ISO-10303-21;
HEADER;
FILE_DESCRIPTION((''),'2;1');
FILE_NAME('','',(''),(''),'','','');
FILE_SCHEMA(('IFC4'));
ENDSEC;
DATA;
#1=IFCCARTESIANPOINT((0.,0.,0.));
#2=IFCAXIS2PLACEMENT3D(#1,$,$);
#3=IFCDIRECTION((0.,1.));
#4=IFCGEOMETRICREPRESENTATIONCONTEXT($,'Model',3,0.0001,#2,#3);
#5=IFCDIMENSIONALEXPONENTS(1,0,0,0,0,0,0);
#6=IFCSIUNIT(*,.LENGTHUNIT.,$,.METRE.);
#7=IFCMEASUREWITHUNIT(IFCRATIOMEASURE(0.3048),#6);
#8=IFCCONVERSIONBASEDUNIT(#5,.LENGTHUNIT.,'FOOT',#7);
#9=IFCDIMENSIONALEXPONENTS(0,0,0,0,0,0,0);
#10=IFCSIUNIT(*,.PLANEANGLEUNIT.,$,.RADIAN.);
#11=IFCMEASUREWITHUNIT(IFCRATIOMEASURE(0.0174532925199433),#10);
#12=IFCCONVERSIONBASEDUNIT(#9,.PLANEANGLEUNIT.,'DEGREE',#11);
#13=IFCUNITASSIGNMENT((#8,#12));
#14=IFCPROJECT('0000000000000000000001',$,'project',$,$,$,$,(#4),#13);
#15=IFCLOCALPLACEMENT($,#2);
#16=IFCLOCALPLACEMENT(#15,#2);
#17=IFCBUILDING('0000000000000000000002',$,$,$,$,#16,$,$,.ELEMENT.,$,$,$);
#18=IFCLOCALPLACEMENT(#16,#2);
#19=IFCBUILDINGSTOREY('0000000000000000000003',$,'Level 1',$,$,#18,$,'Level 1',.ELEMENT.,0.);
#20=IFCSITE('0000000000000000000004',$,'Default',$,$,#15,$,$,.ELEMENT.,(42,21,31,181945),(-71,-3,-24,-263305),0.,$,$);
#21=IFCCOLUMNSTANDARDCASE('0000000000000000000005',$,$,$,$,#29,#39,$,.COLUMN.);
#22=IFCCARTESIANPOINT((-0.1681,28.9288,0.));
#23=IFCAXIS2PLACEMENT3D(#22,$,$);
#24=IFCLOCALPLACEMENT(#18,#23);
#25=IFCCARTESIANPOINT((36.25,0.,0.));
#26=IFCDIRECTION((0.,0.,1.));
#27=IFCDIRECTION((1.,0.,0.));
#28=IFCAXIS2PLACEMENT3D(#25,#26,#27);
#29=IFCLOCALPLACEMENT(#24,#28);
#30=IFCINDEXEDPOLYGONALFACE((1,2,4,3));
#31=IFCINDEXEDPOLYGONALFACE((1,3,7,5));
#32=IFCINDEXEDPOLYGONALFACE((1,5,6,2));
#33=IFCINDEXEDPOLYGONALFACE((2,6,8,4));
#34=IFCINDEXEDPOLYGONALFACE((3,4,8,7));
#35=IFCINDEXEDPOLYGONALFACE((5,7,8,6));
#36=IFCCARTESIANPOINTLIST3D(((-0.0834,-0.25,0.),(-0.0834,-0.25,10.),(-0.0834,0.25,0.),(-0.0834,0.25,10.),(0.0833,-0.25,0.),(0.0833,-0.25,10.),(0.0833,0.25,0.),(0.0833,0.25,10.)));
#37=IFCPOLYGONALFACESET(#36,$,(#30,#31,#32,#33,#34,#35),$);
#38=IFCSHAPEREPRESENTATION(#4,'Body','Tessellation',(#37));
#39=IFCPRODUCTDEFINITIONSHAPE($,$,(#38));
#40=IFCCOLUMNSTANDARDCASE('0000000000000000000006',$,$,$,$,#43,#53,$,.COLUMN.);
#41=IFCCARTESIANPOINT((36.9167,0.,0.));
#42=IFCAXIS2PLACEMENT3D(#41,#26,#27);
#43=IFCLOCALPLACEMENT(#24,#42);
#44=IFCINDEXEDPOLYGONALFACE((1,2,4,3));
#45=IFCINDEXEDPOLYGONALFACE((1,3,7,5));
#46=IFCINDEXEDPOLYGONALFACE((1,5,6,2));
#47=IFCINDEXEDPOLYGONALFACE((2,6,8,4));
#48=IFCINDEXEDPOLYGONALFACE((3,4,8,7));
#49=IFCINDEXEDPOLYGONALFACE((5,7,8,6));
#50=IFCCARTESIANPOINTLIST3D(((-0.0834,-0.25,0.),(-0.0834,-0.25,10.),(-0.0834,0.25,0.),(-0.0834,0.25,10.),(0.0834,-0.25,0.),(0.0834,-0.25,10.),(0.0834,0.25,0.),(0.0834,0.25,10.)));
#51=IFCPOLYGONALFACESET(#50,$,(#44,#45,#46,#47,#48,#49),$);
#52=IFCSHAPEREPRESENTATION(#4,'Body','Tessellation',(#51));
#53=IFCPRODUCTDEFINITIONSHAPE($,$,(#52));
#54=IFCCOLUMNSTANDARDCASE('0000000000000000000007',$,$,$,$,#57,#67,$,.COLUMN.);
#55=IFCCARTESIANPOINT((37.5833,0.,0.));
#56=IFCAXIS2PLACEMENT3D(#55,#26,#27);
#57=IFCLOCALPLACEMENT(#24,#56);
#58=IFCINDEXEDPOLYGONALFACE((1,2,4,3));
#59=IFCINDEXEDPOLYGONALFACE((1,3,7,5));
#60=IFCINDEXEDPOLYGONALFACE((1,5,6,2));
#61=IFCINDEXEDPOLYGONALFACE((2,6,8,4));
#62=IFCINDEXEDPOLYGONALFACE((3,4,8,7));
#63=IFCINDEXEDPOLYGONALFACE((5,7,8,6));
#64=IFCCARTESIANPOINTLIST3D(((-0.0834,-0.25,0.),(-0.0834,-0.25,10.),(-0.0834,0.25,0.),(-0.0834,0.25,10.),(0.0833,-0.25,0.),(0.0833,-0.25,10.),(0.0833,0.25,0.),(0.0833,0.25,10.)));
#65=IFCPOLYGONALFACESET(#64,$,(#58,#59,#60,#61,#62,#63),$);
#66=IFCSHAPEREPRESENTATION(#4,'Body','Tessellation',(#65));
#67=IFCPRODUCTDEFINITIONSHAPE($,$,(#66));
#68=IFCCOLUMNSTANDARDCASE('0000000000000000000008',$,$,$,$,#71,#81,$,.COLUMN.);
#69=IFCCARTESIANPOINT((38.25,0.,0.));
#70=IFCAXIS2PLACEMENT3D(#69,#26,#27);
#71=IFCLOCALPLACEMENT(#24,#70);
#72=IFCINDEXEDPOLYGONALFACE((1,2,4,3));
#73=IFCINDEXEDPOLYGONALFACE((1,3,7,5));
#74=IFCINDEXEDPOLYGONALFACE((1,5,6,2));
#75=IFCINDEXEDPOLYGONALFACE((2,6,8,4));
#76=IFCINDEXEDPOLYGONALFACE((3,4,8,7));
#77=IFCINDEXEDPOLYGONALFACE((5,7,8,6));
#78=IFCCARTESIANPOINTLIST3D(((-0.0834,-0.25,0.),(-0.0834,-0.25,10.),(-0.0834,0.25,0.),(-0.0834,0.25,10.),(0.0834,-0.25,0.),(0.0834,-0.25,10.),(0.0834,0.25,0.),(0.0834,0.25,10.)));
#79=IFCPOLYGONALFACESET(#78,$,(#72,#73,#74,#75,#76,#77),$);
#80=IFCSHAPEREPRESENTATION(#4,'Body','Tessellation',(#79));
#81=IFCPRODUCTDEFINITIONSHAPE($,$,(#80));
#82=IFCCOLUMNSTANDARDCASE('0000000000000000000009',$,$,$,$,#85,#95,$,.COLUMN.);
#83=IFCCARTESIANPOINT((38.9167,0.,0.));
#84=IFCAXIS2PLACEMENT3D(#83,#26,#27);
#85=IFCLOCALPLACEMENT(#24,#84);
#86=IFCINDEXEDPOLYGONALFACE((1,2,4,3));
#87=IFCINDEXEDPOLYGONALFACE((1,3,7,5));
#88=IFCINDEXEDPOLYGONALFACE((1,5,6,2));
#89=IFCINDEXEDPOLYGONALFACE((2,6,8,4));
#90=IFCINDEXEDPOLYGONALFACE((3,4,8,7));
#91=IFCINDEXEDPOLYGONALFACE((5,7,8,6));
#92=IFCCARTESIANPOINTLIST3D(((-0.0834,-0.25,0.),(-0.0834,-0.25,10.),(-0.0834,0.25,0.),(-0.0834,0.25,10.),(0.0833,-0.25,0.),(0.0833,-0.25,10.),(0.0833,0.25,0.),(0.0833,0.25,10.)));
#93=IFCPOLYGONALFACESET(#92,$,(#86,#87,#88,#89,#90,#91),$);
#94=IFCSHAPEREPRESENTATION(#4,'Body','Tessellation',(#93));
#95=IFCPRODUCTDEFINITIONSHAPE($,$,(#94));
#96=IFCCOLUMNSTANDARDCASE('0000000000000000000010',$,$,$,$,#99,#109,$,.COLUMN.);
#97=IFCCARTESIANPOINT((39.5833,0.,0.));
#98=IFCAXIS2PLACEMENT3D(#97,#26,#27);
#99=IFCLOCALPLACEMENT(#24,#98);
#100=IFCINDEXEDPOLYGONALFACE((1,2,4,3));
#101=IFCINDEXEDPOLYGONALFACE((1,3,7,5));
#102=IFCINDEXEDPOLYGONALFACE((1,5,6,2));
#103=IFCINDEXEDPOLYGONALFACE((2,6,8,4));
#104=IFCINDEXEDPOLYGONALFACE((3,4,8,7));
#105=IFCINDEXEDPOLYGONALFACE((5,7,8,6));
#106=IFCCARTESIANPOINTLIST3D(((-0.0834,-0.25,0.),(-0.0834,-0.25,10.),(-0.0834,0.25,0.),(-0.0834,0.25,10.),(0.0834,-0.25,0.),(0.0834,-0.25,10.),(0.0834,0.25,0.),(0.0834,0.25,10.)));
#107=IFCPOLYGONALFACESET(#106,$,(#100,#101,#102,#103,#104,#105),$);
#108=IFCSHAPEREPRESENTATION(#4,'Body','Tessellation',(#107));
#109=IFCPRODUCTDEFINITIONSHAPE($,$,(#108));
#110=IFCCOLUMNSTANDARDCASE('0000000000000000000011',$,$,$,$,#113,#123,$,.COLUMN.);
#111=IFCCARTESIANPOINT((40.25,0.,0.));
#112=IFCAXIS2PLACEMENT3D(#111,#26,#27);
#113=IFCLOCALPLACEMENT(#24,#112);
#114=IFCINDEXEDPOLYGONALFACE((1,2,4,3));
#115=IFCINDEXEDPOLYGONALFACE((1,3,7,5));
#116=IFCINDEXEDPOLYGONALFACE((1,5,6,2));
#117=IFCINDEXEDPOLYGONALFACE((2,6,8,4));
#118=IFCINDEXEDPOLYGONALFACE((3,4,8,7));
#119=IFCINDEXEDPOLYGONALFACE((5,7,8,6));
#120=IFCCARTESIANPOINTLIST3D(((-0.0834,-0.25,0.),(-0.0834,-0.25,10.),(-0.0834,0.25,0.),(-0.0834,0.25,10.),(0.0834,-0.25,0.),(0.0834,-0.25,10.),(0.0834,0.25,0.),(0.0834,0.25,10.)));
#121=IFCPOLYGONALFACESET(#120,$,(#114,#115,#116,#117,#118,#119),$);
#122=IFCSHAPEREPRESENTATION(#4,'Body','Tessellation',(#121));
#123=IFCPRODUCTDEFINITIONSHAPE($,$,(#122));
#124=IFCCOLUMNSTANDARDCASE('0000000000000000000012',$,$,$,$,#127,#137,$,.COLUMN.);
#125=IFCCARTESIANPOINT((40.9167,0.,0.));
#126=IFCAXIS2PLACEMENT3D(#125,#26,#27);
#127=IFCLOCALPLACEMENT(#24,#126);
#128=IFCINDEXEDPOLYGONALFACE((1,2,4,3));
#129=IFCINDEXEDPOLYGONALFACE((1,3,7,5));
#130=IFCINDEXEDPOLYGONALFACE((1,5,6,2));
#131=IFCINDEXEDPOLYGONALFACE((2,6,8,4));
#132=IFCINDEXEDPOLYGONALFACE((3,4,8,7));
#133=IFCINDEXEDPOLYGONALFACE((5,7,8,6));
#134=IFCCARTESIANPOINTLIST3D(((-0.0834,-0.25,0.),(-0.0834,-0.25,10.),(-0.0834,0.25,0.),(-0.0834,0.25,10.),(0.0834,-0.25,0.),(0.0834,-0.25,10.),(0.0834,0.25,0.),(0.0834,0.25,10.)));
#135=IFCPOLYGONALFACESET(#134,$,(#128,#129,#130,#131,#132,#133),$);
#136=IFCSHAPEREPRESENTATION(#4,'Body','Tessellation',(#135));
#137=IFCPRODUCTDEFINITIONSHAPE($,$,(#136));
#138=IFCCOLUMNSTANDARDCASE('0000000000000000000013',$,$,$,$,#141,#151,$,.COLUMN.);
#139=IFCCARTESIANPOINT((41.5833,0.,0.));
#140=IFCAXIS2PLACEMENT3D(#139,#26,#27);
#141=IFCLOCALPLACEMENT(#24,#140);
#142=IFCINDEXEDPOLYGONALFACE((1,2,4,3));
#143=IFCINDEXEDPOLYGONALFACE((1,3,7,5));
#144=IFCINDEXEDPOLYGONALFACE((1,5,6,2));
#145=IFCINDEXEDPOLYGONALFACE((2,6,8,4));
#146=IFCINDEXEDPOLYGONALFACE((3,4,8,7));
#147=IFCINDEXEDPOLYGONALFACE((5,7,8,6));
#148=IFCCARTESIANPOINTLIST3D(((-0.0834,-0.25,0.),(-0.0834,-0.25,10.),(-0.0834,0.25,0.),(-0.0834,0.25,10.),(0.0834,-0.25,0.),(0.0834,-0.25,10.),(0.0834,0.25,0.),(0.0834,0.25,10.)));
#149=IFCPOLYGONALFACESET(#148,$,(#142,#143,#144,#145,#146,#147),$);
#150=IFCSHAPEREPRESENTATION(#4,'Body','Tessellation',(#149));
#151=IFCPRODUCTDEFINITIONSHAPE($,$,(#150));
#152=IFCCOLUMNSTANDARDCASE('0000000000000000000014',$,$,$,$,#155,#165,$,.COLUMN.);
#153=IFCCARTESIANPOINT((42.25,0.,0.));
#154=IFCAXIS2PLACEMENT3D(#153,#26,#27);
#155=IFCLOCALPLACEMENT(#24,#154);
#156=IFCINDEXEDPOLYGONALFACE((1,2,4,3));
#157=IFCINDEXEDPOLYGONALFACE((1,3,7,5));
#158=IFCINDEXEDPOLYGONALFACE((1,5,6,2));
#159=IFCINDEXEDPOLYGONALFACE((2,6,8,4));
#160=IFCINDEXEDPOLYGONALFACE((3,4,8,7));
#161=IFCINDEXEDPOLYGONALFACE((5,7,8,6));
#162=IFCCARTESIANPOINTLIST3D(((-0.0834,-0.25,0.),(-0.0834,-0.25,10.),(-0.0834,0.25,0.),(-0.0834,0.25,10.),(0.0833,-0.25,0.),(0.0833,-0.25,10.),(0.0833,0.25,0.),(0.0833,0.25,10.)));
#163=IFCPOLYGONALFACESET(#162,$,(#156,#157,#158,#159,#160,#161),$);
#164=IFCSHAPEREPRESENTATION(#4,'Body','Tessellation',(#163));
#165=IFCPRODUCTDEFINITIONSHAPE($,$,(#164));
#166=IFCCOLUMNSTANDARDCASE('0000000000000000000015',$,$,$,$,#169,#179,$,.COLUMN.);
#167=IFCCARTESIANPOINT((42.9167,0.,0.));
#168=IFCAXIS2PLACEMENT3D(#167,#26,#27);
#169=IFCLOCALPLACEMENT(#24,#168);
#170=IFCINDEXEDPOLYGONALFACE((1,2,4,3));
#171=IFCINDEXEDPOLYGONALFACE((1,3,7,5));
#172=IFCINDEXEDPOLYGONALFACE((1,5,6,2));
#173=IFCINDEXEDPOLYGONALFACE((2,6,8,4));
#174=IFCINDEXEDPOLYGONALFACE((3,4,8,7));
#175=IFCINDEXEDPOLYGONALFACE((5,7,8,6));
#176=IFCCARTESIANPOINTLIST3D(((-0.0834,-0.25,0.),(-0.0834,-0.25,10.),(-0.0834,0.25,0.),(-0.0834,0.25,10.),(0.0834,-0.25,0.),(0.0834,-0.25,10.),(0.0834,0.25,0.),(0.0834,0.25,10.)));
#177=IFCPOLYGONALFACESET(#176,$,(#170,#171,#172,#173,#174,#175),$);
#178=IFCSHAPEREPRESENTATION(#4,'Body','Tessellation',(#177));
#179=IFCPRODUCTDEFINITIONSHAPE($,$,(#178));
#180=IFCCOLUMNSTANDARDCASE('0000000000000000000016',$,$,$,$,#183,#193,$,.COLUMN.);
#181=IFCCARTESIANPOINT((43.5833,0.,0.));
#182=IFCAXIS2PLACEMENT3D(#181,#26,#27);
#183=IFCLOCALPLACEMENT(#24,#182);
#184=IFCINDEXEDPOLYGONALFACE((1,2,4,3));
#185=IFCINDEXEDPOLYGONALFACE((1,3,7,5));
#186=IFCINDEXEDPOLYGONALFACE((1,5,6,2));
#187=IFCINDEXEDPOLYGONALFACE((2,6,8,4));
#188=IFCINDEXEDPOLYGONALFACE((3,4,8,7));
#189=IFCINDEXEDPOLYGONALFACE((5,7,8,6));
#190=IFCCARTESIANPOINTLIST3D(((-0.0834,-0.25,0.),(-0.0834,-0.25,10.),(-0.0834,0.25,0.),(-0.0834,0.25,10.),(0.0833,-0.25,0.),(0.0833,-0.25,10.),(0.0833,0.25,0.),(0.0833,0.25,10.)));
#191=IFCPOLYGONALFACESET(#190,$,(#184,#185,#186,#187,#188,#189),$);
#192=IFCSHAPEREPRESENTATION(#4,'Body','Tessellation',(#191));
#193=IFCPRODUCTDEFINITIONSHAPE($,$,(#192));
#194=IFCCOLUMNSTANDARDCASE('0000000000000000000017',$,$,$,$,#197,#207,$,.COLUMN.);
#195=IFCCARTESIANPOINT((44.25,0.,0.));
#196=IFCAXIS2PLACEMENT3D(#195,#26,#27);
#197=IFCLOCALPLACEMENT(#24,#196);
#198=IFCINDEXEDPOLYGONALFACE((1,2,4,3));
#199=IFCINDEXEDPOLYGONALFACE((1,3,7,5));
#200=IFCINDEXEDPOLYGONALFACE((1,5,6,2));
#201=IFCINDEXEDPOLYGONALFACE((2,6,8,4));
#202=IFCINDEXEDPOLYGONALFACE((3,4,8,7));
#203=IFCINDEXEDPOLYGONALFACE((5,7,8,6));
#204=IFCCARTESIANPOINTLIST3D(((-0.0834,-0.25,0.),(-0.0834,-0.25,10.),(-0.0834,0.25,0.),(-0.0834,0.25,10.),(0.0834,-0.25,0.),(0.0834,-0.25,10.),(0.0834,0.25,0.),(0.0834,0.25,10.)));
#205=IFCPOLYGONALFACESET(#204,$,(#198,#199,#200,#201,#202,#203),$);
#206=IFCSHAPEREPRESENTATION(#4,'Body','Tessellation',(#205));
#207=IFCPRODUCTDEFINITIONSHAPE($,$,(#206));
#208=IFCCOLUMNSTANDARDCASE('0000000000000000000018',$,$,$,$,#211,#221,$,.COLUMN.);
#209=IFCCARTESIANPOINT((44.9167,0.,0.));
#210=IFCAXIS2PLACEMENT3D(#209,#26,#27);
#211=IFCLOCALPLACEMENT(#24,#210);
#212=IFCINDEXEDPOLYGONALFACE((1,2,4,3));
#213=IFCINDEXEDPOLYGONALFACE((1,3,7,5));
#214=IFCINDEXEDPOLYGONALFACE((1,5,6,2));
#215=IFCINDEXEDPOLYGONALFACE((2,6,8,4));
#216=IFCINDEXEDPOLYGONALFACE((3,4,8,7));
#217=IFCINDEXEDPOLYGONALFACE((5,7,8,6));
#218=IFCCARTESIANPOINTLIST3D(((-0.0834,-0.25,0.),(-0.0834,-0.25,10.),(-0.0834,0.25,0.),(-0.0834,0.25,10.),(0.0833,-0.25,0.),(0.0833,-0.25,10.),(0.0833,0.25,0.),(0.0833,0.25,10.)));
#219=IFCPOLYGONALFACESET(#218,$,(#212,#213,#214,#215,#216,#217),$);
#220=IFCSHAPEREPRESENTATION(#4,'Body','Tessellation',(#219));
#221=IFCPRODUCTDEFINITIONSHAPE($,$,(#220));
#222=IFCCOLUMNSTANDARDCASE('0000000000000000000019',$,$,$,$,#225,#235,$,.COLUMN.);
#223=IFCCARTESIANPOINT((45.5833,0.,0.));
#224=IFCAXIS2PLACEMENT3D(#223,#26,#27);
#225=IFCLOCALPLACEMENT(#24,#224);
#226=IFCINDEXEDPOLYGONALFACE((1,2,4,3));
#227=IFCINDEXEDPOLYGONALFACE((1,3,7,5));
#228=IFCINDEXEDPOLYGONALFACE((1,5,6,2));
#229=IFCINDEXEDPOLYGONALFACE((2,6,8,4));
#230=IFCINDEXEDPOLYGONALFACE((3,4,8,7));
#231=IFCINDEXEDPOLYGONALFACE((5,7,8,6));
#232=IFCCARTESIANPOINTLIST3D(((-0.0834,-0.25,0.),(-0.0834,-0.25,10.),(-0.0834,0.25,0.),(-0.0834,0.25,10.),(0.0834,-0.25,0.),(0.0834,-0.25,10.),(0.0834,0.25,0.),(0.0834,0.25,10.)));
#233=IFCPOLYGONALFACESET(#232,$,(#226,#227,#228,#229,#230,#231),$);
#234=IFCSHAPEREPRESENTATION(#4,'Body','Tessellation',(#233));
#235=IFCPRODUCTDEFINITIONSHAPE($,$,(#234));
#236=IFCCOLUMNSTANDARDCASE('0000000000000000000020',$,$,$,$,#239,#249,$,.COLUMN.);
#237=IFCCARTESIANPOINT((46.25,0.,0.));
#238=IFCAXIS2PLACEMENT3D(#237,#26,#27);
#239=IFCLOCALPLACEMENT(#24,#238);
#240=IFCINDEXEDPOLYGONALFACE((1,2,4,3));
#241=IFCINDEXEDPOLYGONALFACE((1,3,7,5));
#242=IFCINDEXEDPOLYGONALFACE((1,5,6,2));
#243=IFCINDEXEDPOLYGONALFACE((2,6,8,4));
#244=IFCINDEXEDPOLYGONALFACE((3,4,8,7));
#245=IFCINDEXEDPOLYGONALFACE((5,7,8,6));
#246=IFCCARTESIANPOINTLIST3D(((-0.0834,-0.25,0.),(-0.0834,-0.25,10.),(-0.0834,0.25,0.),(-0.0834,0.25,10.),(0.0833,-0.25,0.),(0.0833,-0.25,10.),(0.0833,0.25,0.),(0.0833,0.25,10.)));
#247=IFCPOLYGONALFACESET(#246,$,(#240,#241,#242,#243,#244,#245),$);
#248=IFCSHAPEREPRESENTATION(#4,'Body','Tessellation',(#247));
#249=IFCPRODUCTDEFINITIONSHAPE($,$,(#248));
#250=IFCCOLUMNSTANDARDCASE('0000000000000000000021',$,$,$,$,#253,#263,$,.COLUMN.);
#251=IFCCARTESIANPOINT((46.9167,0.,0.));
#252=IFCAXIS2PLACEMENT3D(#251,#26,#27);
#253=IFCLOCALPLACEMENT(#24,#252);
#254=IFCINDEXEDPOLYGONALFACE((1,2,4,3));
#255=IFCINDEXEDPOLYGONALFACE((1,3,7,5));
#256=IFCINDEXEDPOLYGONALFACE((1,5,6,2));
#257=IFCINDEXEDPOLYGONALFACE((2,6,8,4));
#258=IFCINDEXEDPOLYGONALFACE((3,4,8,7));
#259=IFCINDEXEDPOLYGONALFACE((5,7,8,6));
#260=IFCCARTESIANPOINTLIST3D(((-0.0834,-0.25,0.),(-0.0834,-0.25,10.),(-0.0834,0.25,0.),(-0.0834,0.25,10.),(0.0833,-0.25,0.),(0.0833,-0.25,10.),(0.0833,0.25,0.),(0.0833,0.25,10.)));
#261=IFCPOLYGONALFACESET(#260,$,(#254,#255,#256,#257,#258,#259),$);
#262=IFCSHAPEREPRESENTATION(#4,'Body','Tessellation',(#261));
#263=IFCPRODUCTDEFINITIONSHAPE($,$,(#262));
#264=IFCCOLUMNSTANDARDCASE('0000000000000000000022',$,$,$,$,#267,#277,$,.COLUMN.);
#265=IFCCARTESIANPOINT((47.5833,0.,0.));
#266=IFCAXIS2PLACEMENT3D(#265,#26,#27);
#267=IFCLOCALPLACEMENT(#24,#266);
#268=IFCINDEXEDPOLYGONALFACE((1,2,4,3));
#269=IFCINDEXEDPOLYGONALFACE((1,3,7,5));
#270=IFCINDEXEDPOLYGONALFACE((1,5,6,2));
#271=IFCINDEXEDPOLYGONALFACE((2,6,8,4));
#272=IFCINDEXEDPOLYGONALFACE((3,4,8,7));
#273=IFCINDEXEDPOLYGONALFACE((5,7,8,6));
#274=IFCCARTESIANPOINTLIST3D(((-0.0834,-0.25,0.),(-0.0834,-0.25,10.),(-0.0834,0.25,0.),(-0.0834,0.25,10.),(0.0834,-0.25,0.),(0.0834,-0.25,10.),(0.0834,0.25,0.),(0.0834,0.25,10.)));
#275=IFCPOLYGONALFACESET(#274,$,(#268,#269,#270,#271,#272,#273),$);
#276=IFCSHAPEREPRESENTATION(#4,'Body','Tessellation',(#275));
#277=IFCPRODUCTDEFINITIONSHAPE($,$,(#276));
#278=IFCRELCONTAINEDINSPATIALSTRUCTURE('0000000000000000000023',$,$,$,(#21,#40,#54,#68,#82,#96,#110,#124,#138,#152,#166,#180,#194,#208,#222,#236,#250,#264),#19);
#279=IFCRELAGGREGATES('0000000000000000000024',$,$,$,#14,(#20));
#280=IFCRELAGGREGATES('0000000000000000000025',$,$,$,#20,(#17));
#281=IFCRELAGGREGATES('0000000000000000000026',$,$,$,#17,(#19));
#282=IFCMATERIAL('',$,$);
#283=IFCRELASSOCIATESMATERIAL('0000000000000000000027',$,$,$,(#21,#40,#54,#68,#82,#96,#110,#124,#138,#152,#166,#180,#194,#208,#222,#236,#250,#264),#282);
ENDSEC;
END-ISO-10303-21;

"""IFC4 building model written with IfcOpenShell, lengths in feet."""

from ifc_helpers import new_model, entity, si_unit, converted_unit, direction, frame, origin, place, context, project, spatial, rectangle, extrude, material, element, save


model = new_model("IFC4")

# Units and contexts
model_context = context("Model", 3, precision=0.0001, world=origin(), true_north=direction((0.0, 1.0)))
ifc_project = project(units=[converted_unit("LENGTHUNIT", "FOOT", entity("IfcRatioMeasure", 0.3048), si_unit("LENGTHUNIT", "METRE"), dimensions=[1, 0, 0, 0, 0, 0, 0]), converted_unit("PLANEANGLEUNIT", "DEGREE", entity("IfcRatioMeasure", 0.0174532925199433), si_unit("PLANEANGLEUNIT", "RADIAN"), dimensions=[0, 0, 0, 0, 0, 0, 0])], contexts=[model_context])

# Site, building, storey
site_placement = place(None, origin())
site = spatial("IfcSite", under=ifc_project, at=site_placement, Name="Default", CompositionType="ELEMENT", RefLatitude=(42, 21, 31, 181945), RefLongitude=(-71, -3, -24, -263305), RefElevation=0.0)
building_placement = place(site_placement, origin())
building = spatial("IfcBuilding", under=site, at=building_placement, CompositionType="ELEMENT")
storey_placement = place(building_placement, origin())
storey = spatial("IfcBuildingStorey", under=building, at=storey_placement, Name="Level 1", LongName="Level 1", CompositionType="ELEMENT", Elevation=0.0)

# Columns
ifc_material_1 = material(Name="")
placement = place(storey_placement, frame((-0.1681, 28.9288, 0.0)))
for number, where, z_axis, x_axis in (
    (1, (36.25, 0.0, 0.0), (0.0, 0.0, 1.0), (1.0, 0.0, 0.0)),
    (2, (36.9167, 0.0, 0.0), (0.0, 0.0, 1.0), (1.0, 0.0, 0.0)),
    (3, (37.5833, 0.0, 0.0), (0.0, 0.0, 1.0), (1.0, 0.0, 0.0)),
    (4, (38.25, 0.0, 0.0), (0.0, 0.0, 1.0), (1.0, 0.0, 0.0)),
    (5, (38.9167, 0.0, 0.0), (0.0, 0.0, 1.0), (1.0, 0.0, 0.0)),
    (6, (39.5833, 0.0, 0.0), (0.0, 0.0, 1.0), (1.0, 0.0, 0.0)),
    (7, (40.25, 0.0, 0.0), (0.0, 0.0, 1.0), (1.0, 0.0, 0.0)),
    (8, (40.9167, 0.0, 0.0), (0.0, 0.0, 1.0), (1.0, 0.0, 0.0)),
    (9, (41.5833, 0.0, 0.0), (0.0, 0.0, 1.0), (1.0, 0.0, 0.0)),
    (10, (42.25, 0.0, 0.0), (0.0, 0.0, 1.0), (1.0, 0.0, 0.0)),
    (11, (42.9167, 0.0, 0.0), (0.0, 0.0, 1.0), (1.0, 0.0, 0.0)),
    (12, (43.5833, 0.0, 0.0), (0.0, 0.0, 1.0), (1.0, 0.0, 0.0)),
    (13, (44.25, 0.0, 0.0), (0.0, 0.0, 1.0), (1.0, 0.0, 0.0)),
    (14, (44.9167, 0.0, 0.0), (0.0, 0.0, 1.0), (1.0, 0.0, 0.0)),
    (15, (45.5833, 0.0, 0.0), (0.0, 0.0, 1.0), (1.0, 0.0, 0.0)),
    (16, (46.25, 0.0, 0.0), (0.0, 0.0, 1.0), (1.0, 0.0, 0.0)),
    (17, (46.9167, 0.0, 0.0), (0.0, 0.0, 1.0), (1.0, 0.0, 0.0)),
    (18, (47.5833, 0.0, 0.0), (0.0, 0.0, 1.0), (1.0, 0.0, 0.0)),
):
    element("IfcColumnStandardCase", number, at=place(placement, frame(where, z_axis=z_axis, x_axis=x_axis)), inside=storey, material=ifc_material_1, PredefinedType="COLUMN", context=model_context, shape_type="SweptSolid", body=[
        extrude(rectangle(XDim=0.1667, YDim=0.5), origin(), (0.0, 0.0, 1.0), 10.0),
    ])

save(model, "model.ifc")
